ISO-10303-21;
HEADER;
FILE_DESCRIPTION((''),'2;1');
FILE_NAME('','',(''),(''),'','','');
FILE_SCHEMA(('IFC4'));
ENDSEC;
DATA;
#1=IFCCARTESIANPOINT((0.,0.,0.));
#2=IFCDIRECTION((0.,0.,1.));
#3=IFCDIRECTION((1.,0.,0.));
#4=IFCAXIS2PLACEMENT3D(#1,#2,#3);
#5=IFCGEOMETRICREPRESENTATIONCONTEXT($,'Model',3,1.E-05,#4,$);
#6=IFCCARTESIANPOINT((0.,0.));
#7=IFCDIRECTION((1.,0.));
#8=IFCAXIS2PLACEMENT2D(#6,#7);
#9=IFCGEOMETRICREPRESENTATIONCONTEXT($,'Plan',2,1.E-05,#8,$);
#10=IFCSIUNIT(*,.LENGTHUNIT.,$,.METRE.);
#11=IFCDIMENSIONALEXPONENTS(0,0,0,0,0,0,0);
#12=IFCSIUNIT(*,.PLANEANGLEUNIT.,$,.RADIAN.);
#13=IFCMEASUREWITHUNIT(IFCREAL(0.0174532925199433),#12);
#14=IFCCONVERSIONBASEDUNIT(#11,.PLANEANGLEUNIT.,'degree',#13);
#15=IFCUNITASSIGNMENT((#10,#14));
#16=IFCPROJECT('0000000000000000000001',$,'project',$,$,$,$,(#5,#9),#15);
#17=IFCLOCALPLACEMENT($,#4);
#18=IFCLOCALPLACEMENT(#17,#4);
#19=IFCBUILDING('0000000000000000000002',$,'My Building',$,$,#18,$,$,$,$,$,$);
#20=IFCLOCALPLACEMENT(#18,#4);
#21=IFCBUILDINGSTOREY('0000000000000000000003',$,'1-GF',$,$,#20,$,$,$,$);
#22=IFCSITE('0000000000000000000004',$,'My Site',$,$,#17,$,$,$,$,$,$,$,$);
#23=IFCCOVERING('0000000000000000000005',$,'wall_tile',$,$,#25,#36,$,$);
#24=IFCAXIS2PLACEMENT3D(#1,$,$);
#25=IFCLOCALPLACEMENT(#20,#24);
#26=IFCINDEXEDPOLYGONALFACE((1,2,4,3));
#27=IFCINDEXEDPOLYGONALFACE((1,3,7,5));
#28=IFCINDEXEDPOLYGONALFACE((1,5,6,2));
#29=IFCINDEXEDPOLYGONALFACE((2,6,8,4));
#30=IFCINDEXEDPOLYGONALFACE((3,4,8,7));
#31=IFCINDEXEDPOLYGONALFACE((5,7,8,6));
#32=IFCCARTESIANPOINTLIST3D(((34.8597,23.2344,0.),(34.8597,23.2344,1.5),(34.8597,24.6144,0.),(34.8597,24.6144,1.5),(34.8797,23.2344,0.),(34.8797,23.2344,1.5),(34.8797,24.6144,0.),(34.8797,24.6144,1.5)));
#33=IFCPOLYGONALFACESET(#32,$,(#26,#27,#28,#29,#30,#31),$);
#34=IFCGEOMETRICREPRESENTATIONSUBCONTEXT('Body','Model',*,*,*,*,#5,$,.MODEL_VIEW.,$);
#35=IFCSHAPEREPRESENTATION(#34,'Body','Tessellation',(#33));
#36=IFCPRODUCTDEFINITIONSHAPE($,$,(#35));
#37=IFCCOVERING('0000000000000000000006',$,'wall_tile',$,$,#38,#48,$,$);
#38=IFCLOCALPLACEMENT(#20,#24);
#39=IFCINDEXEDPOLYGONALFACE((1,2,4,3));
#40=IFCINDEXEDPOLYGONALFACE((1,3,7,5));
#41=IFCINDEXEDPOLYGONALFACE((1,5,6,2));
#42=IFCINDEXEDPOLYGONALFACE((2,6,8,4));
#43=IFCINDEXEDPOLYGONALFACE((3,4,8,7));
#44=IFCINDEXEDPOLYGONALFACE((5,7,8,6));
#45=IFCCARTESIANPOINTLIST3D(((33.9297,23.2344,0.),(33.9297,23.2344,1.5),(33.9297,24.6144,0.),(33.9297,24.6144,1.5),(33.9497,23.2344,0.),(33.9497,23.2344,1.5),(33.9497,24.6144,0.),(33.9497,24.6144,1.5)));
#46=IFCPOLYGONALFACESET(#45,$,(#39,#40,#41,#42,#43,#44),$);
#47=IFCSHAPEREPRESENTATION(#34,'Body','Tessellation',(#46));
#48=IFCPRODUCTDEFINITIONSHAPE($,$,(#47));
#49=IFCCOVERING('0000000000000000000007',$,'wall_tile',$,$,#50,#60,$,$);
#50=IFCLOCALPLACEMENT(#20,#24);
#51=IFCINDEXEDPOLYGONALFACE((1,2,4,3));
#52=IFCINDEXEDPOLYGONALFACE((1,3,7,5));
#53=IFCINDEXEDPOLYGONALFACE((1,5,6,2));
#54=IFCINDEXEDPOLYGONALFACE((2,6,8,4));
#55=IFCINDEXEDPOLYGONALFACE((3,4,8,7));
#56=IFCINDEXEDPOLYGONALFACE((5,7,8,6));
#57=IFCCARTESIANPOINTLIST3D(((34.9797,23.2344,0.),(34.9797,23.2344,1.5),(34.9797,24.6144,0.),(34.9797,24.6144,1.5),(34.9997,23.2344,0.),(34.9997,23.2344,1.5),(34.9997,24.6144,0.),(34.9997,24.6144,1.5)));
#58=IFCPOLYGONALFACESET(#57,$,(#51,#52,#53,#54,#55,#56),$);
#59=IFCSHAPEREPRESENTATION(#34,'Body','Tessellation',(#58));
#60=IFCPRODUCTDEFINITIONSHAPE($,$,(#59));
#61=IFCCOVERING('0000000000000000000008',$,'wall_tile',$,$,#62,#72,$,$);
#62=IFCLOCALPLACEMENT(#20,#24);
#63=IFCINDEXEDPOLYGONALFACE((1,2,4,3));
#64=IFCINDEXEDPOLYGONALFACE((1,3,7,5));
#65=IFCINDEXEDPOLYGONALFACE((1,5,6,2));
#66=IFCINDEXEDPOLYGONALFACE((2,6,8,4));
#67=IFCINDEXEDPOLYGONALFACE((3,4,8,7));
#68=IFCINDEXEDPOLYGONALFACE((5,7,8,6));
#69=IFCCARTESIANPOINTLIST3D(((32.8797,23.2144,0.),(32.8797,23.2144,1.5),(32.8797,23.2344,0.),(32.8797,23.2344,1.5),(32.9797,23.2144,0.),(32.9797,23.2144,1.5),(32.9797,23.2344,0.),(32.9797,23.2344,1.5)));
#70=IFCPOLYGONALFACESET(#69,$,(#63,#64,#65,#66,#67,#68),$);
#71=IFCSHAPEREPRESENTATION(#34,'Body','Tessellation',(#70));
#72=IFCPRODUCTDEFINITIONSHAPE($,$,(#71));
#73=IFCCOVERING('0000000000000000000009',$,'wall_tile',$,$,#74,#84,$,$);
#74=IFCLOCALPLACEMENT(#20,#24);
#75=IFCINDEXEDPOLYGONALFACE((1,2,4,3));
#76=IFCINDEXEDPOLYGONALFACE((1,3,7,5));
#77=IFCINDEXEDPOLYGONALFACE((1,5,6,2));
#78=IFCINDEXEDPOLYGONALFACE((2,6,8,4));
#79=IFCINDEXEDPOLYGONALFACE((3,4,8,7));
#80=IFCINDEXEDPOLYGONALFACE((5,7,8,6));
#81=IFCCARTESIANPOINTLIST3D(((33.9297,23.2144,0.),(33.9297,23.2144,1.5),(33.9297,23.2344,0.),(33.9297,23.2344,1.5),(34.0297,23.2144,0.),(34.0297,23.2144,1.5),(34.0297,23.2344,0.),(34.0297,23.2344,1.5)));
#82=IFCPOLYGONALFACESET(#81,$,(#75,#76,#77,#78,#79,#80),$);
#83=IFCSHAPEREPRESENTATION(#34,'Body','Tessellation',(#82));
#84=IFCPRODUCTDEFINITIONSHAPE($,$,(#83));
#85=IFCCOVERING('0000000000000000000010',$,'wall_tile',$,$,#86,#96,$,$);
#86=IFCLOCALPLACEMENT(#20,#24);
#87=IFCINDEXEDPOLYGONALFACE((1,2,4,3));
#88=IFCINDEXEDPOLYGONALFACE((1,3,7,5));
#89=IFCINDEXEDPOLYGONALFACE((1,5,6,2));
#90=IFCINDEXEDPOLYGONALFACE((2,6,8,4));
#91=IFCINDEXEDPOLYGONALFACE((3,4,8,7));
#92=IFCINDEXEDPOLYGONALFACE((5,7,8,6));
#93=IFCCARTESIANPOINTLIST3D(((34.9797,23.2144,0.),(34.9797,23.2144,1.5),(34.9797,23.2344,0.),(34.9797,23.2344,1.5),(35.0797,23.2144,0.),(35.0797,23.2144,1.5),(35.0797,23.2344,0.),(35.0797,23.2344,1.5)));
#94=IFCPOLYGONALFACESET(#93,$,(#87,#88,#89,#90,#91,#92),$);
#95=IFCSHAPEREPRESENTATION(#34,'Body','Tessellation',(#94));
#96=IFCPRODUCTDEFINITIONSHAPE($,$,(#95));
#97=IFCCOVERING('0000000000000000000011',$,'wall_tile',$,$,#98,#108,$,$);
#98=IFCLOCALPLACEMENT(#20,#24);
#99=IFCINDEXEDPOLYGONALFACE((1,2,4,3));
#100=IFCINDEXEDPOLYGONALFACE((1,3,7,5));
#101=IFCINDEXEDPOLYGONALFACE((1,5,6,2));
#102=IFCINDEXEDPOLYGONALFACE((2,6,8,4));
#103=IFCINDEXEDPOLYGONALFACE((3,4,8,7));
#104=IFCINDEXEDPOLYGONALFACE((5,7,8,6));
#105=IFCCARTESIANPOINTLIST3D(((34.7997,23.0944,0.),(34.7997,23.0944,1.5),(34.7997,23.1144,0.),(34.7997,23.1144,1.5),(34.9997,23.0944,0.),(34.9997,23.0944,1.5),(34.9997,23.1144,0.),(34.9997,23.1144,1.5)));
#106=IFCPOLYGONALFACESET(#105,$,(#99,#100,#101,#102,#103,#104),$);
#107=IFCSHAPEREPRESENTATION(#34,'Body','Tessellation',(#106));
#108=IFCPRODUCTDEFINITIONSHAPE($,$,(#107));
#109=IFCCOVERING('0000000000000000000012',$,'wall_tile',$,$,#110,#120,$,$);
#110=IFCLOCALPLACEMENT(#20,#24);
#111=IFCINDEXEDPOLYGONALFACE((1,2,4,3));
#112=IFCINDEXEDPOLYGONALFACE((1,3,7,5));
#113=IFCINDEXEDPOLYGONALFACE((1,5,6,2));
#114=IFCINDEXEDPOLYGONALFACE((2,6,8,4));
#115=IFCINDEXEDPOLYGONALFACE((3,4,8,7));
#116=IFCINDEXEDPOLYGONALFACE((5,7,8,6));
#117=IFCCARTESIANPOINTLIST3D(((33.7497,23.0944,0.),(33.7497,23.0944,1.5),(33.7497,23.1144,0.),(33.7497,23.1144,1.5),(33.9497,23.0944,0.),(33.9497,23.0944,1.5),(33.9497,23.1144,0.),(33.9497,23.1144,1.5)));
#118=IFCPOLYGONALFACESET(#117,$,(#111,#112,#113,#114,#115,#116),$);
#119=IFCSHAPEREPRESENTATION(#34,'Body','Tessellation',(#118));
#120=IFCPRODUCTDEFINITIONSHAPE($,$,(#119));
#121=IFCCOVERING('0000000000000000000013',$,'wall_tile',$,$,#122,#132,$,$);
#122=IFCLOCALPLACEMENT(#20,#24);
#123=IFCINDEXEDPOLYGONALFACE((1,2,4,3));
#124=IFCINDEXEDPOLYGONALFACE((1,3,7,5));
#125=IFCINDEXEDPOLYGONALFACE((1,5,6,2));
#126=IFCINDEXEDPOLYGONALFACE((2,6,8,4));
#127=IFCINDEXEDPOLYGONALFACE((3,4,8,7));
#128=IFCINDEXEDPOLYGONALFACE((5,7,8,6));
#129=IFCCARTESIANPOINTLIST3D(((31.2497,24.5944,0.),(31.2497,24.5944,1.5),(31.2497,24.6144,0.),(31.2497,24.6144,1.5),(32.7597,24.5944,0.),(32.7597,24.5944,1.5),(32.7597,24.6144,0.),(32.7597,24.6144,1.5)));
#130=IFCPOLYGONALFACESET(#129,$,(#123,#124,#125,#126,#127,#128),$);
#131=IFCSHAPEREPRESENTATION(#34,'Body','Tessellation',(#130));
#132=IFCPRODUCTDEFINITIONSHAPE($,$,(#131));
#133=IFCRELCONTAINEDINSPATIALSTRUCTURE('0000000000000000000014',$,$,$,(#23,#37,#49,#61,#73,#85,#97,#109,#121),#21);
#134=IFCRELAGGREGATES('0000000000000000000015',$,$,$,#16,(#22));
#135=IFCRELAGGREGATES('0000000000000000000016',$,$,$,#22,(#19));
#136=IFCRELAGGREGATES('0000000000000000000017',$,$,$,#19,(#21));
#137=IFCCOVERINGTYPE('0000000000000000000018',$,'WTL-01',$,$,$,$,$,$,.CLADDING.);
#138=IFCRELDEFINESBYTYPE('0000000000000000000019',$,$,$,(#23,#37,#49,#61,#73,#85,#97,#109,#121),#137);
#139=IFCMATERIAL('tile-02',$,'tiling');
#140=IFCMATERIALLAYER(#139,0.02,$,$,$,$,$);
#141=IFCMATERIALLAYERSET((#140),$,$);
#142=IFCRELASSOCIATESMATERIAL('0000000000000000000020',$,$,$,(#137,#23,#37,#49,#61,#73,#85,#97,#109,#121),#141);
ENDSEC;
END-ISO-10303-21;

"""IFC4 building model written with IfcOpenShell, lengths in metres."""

from ifc_helpers import new_model, entity, si_unit, converted_unit, frame, origin_with_axes, origin_2d_with_axis, place, context, subcontext, project, spatial, indexed_curve, outline, extrude, material, layer, layer_set, layer_usage, type_object, element, save


model = new_model("IFC4")

# Units and contexts
model_context = context("Model", 3, precision=1e-05, world=origin_with_axes())
plan_context = context("Plan", 2, precision=1e-05, world=origin_2d_with_axis())
body_context_1 = subcontext(model_context, "Body", "Model", "MODEL_VIEW")
ifc_project = project(units=[si_unit("LENGTHUNIT", "METRE"), converted_unit("PLANEANGLEUNIT", "degree", entity("IfcReal", 0.0174532925199433), si_unit("PLANEANGLEUNIT", "RADIAN"), dimensions=[0, 0, 0, 0, 0, 0, 0])], contexts=[model_context, plan_context])

# Site, building, storey
site_placement = place(None, origin_with_axes())
site = spatial("IfcSite", under=ifc_project, at=site_placement, Name="My Site")
building_placement = place(site_placement, origin_with_axes())
building = spatial("IfcBuilding", under=site, at=building_placement, Name="My Building")
storey_placement = place(building_placement, origin_with_axes())
storey = spatial("IfcBuildingStorey", under=building, at=storey_placement, Name="1-GF")

# Coverings
ifc_material_1 = material(Name="tile-02", Category="tiling")
ifc_layer_1 = layer(ifc_material_1, 0.02)
ifc_layer_set_1 = layer_set([ifc_layer_1])
covering_type_1 = type_object("IfcCoveringType", Name="WTL-01", PredefinedType="CLADDING", material=ifc_layer_set_1)
ifc_layer_usage_1 = layer_usage(ifc_layer_set_1, "AXIS2", "POSITIVE", 0.0)
covering_1_placement = place(storey_placement, frame((34.8797, 23.2344, 0.0), z_axis=(0.0, 0.0, 1.0), x_axis=(0.000001, 1.0, 0.0)))
element("IfcCovering", 1, at=covering_1_placement, inside=storey, type_object=covering_type_1, material=ifc_layer_usage_1, Name="wall_tile", context=body_context_1, shape_type="SweptSolid", body=[
    extrude(outline(indexed_curve([(0.0, 0.0), (0.0, 0.02), (1.38, 0.02), (1.38, 0.0), (0.0, 0.0)], self_intersect=False)), origin_with_axes(), (0.0, 0.0, 1.0), 1.5),
])
ifc_layer_usage_2 = layer_usage(ifc_layer_set_1, "AXIS2", "POSITIVE", 0.0)
covering_2_placement = place(storey_placement, frame((33.9497, 23.2344, 0.0), z_axis=(0.0, 0.0, 1.0), x_axis=(0.000001, 1.0, 0.0)))
element("IfcCovering", 2, at=covering_2_placement, inside=storey, type_object=covering_type_1, material=ifc_layer_usage_2, Name="wall_tile", context=body_context_1, shape_type="SweptSolid", body=[
    extrude(outline(indexed_curve([(0.0, 0.0), (0.0, 0.02), (1.38, 0.02), (1.38, 0.0), (0.0, 0.0)], self_intersect=False)), origin_with_axes(), (0.0, 0.0, 1.0), 1.5),
])
ifc_layer_usage_3 = layer_usage(ifc_layer_set_1, "AXIS2", "POSITIVE", 0.0)
covering_3_placement = place(storey_placement, frame((34.9997, 23.2344, 0.0), z_axis=(0.0, 0.0, 1.0), x_axis=(0.000001, 1.0, 0.0)))
element("IfcCovering", 3, at=covering_3_placement, inside=storey, type_object=covering_type_1, material=ifc_layer_usage_3, Name="wall_tile", context=body_context_1, shape_type="SweptSolid", body=[
    extrude(outline(indexed_curve([(0.0, 0.0), (0.0, 0.02), (1.38, 0.02), (1.38, 0.0), (0.0, 0.0)], self_intersect=False)), origin_with_axes(), (0.0, 0.0, 1.0), 1.5),
])
ifc_layer_usage_4 = layer_usage(ifc_layer_set_1, "AXIS2", "POSITIVE", 0.0)
covering_4_placement = place(storey_placement, frame((32.9797, 23.2344, 0.0), z_axis=(0.0, 0.0, 1.0), x_axis=(-1.0, 0.000001, 0.0)))
element("IfcCovering", 4, at=covering_4_placement, inside=storey, type_object=covering_type_1, material=ifc_layer_usage_4, Name="wall_tile", context=body_context_1, shape_type="SweptSolid", body=[
    extrude(outline(indexed_curve([(0.0, 0.0), (0.0, 0.02), (0.1, 0.02), (0.1, 0.0), (0.0, 0.0)], self_intersect=False)), origin_with_axes(), (0.0, 0.0, 1.0), 1.5),
])
ifc_layer_usage_5 = layer_usage(ifc_layer_set_1, "AXIS2", "POSITIVE", 0.0)
covering_5_placement = place(storey_placement, frame((34.0297, 23.2344, 0.0), z_axis=(0.0, 0.0, 1.0), x_axis=(-1.0, 0.000001, 0.0)))
element("IfcCovering", 5, at=covering_5_placement, inside=storey, type_object=covering_type_1, material=ifc_layer_usage_5, Name="wall_tile", context=body_context_1, shape_type="SweptSolid", body=[
    extrude(outline(indexed_curve([(0.0, 0.0), (0.0, 0.02), (0.1, 0.02), (0.1, 0.0), (0.0, 0.0)], self_intersect=False)), origin_with_axes(), (0.0, 0.0, 1.0), 1.5),
])
ifc_layer_usage_6 = layer_usage(ifc_layer_set_1, "AXIS2", "POSITIVE", 0.0)
covering_6_placement = place(storey_placement, frame((35.0797, 23.2344, 0.0), z_axis=(0.0, 0.0, 1.0), x_axis=(-1.0, 0.000001, 0.0)))
element("IfcCovering", 6, at=covering_6_placement, inside=storey, type_object=covering_type_1, material=ifc_layer_usage_6, Name="wall_tile", context=body_context_1, shape_type="SweptSolid", body=[
    extrude(outline(indexed_curve([(0.0, 0.0), (0.0, 0.02), (0.1, 0.02), (0.1, 0.0), (0.0, 0.0)], self_intersect=False)), origin_with_axes(), (0.0, 0.0, 1.0), 1.5),
])
ifc_layer_usage_7 = layer_usage(ifc_layer_set_1, "AXIS2", "POSITIVE", 0.0)
covering_7_placement = place(storey_placement, frame((34.9997, 23.1144, 0.0), z_axis=(0.0, 0.0, 1.0), x_axis=(-1.0, 0.000001, 0.0)))
element("IfcCovering", 7, at=covering_7_placement, inside=storey, type_object=covering_type_1, material=ifc_layer_usage_7, Name="wall_tile", context=body_context_1, shape_type="SweptSolid", body=[
    extrude(outline(indexed_curve([(0.0, 0.0), (0.0, 0.02), (0.2, 0.02), (0.2, 0.0), (0.0, 0.0)], self_intersect=False)), origin_with_axes(), (0.0, 0.0, 1.0), 1.5),
])
ifc_layer_usage_8 = layer_usage(ifc_layer_set_1, "AXIS2", "POSITIVE", 0.0)
covering_8_placement = place(storey_placement, frame((33.9497, 23.1144, 0.0), z_axis=(0.0, 0.0, 1.0), x_axis=(-1.0, 0.000001, 0.0)))
element("IfcCovering", 8, at=covering_8_placement, inside=storey, type_object=covering_type_1, material=ifc_layer_usage_8, Name="wall_tile", context=body_context_1, shape_type="SweptSolid", body=[
    extrude(outline(indexed_curve([(0.0, 0.0), (0.0, 0.02), (0.2, 0.02), (0.2, 0.0), (0.0, 0.0)], self_intersect=False)), origin_with_axes(), (0.0, 0.0, 1.0), 1.5),
])
ifc_layer_usage_9 = layer_usage(ifc_layer_set_1, "AXIS2", "POSITIVE", 0.0)
covering_9_placement = place(storey_placement, frame((32.7597, 24.6144, 0.0), z_axis=(0.0, 0.0, 1.0), x_axis=(-1.0, 0.000001, 0.0)))
element("IfcCovering", 9, at=covering_9_placement, inside=storey, type_object=covering_type_1, material=ifc_layer_usage_9, Name="wall_tile", context=body_context_1, shape_type="SweptSolid", body=[
    extrude(outline(indexed_curve([(0.0, 0.0), (0.0, 0.02), (1.51, 0.02), (1.51, 0.0), (0.0, 0.0)], self_intersect=False)), origin_with_axes(), (0.0, 0.0, 1.0), 1.5),
])

save(model, "model.ifc")
